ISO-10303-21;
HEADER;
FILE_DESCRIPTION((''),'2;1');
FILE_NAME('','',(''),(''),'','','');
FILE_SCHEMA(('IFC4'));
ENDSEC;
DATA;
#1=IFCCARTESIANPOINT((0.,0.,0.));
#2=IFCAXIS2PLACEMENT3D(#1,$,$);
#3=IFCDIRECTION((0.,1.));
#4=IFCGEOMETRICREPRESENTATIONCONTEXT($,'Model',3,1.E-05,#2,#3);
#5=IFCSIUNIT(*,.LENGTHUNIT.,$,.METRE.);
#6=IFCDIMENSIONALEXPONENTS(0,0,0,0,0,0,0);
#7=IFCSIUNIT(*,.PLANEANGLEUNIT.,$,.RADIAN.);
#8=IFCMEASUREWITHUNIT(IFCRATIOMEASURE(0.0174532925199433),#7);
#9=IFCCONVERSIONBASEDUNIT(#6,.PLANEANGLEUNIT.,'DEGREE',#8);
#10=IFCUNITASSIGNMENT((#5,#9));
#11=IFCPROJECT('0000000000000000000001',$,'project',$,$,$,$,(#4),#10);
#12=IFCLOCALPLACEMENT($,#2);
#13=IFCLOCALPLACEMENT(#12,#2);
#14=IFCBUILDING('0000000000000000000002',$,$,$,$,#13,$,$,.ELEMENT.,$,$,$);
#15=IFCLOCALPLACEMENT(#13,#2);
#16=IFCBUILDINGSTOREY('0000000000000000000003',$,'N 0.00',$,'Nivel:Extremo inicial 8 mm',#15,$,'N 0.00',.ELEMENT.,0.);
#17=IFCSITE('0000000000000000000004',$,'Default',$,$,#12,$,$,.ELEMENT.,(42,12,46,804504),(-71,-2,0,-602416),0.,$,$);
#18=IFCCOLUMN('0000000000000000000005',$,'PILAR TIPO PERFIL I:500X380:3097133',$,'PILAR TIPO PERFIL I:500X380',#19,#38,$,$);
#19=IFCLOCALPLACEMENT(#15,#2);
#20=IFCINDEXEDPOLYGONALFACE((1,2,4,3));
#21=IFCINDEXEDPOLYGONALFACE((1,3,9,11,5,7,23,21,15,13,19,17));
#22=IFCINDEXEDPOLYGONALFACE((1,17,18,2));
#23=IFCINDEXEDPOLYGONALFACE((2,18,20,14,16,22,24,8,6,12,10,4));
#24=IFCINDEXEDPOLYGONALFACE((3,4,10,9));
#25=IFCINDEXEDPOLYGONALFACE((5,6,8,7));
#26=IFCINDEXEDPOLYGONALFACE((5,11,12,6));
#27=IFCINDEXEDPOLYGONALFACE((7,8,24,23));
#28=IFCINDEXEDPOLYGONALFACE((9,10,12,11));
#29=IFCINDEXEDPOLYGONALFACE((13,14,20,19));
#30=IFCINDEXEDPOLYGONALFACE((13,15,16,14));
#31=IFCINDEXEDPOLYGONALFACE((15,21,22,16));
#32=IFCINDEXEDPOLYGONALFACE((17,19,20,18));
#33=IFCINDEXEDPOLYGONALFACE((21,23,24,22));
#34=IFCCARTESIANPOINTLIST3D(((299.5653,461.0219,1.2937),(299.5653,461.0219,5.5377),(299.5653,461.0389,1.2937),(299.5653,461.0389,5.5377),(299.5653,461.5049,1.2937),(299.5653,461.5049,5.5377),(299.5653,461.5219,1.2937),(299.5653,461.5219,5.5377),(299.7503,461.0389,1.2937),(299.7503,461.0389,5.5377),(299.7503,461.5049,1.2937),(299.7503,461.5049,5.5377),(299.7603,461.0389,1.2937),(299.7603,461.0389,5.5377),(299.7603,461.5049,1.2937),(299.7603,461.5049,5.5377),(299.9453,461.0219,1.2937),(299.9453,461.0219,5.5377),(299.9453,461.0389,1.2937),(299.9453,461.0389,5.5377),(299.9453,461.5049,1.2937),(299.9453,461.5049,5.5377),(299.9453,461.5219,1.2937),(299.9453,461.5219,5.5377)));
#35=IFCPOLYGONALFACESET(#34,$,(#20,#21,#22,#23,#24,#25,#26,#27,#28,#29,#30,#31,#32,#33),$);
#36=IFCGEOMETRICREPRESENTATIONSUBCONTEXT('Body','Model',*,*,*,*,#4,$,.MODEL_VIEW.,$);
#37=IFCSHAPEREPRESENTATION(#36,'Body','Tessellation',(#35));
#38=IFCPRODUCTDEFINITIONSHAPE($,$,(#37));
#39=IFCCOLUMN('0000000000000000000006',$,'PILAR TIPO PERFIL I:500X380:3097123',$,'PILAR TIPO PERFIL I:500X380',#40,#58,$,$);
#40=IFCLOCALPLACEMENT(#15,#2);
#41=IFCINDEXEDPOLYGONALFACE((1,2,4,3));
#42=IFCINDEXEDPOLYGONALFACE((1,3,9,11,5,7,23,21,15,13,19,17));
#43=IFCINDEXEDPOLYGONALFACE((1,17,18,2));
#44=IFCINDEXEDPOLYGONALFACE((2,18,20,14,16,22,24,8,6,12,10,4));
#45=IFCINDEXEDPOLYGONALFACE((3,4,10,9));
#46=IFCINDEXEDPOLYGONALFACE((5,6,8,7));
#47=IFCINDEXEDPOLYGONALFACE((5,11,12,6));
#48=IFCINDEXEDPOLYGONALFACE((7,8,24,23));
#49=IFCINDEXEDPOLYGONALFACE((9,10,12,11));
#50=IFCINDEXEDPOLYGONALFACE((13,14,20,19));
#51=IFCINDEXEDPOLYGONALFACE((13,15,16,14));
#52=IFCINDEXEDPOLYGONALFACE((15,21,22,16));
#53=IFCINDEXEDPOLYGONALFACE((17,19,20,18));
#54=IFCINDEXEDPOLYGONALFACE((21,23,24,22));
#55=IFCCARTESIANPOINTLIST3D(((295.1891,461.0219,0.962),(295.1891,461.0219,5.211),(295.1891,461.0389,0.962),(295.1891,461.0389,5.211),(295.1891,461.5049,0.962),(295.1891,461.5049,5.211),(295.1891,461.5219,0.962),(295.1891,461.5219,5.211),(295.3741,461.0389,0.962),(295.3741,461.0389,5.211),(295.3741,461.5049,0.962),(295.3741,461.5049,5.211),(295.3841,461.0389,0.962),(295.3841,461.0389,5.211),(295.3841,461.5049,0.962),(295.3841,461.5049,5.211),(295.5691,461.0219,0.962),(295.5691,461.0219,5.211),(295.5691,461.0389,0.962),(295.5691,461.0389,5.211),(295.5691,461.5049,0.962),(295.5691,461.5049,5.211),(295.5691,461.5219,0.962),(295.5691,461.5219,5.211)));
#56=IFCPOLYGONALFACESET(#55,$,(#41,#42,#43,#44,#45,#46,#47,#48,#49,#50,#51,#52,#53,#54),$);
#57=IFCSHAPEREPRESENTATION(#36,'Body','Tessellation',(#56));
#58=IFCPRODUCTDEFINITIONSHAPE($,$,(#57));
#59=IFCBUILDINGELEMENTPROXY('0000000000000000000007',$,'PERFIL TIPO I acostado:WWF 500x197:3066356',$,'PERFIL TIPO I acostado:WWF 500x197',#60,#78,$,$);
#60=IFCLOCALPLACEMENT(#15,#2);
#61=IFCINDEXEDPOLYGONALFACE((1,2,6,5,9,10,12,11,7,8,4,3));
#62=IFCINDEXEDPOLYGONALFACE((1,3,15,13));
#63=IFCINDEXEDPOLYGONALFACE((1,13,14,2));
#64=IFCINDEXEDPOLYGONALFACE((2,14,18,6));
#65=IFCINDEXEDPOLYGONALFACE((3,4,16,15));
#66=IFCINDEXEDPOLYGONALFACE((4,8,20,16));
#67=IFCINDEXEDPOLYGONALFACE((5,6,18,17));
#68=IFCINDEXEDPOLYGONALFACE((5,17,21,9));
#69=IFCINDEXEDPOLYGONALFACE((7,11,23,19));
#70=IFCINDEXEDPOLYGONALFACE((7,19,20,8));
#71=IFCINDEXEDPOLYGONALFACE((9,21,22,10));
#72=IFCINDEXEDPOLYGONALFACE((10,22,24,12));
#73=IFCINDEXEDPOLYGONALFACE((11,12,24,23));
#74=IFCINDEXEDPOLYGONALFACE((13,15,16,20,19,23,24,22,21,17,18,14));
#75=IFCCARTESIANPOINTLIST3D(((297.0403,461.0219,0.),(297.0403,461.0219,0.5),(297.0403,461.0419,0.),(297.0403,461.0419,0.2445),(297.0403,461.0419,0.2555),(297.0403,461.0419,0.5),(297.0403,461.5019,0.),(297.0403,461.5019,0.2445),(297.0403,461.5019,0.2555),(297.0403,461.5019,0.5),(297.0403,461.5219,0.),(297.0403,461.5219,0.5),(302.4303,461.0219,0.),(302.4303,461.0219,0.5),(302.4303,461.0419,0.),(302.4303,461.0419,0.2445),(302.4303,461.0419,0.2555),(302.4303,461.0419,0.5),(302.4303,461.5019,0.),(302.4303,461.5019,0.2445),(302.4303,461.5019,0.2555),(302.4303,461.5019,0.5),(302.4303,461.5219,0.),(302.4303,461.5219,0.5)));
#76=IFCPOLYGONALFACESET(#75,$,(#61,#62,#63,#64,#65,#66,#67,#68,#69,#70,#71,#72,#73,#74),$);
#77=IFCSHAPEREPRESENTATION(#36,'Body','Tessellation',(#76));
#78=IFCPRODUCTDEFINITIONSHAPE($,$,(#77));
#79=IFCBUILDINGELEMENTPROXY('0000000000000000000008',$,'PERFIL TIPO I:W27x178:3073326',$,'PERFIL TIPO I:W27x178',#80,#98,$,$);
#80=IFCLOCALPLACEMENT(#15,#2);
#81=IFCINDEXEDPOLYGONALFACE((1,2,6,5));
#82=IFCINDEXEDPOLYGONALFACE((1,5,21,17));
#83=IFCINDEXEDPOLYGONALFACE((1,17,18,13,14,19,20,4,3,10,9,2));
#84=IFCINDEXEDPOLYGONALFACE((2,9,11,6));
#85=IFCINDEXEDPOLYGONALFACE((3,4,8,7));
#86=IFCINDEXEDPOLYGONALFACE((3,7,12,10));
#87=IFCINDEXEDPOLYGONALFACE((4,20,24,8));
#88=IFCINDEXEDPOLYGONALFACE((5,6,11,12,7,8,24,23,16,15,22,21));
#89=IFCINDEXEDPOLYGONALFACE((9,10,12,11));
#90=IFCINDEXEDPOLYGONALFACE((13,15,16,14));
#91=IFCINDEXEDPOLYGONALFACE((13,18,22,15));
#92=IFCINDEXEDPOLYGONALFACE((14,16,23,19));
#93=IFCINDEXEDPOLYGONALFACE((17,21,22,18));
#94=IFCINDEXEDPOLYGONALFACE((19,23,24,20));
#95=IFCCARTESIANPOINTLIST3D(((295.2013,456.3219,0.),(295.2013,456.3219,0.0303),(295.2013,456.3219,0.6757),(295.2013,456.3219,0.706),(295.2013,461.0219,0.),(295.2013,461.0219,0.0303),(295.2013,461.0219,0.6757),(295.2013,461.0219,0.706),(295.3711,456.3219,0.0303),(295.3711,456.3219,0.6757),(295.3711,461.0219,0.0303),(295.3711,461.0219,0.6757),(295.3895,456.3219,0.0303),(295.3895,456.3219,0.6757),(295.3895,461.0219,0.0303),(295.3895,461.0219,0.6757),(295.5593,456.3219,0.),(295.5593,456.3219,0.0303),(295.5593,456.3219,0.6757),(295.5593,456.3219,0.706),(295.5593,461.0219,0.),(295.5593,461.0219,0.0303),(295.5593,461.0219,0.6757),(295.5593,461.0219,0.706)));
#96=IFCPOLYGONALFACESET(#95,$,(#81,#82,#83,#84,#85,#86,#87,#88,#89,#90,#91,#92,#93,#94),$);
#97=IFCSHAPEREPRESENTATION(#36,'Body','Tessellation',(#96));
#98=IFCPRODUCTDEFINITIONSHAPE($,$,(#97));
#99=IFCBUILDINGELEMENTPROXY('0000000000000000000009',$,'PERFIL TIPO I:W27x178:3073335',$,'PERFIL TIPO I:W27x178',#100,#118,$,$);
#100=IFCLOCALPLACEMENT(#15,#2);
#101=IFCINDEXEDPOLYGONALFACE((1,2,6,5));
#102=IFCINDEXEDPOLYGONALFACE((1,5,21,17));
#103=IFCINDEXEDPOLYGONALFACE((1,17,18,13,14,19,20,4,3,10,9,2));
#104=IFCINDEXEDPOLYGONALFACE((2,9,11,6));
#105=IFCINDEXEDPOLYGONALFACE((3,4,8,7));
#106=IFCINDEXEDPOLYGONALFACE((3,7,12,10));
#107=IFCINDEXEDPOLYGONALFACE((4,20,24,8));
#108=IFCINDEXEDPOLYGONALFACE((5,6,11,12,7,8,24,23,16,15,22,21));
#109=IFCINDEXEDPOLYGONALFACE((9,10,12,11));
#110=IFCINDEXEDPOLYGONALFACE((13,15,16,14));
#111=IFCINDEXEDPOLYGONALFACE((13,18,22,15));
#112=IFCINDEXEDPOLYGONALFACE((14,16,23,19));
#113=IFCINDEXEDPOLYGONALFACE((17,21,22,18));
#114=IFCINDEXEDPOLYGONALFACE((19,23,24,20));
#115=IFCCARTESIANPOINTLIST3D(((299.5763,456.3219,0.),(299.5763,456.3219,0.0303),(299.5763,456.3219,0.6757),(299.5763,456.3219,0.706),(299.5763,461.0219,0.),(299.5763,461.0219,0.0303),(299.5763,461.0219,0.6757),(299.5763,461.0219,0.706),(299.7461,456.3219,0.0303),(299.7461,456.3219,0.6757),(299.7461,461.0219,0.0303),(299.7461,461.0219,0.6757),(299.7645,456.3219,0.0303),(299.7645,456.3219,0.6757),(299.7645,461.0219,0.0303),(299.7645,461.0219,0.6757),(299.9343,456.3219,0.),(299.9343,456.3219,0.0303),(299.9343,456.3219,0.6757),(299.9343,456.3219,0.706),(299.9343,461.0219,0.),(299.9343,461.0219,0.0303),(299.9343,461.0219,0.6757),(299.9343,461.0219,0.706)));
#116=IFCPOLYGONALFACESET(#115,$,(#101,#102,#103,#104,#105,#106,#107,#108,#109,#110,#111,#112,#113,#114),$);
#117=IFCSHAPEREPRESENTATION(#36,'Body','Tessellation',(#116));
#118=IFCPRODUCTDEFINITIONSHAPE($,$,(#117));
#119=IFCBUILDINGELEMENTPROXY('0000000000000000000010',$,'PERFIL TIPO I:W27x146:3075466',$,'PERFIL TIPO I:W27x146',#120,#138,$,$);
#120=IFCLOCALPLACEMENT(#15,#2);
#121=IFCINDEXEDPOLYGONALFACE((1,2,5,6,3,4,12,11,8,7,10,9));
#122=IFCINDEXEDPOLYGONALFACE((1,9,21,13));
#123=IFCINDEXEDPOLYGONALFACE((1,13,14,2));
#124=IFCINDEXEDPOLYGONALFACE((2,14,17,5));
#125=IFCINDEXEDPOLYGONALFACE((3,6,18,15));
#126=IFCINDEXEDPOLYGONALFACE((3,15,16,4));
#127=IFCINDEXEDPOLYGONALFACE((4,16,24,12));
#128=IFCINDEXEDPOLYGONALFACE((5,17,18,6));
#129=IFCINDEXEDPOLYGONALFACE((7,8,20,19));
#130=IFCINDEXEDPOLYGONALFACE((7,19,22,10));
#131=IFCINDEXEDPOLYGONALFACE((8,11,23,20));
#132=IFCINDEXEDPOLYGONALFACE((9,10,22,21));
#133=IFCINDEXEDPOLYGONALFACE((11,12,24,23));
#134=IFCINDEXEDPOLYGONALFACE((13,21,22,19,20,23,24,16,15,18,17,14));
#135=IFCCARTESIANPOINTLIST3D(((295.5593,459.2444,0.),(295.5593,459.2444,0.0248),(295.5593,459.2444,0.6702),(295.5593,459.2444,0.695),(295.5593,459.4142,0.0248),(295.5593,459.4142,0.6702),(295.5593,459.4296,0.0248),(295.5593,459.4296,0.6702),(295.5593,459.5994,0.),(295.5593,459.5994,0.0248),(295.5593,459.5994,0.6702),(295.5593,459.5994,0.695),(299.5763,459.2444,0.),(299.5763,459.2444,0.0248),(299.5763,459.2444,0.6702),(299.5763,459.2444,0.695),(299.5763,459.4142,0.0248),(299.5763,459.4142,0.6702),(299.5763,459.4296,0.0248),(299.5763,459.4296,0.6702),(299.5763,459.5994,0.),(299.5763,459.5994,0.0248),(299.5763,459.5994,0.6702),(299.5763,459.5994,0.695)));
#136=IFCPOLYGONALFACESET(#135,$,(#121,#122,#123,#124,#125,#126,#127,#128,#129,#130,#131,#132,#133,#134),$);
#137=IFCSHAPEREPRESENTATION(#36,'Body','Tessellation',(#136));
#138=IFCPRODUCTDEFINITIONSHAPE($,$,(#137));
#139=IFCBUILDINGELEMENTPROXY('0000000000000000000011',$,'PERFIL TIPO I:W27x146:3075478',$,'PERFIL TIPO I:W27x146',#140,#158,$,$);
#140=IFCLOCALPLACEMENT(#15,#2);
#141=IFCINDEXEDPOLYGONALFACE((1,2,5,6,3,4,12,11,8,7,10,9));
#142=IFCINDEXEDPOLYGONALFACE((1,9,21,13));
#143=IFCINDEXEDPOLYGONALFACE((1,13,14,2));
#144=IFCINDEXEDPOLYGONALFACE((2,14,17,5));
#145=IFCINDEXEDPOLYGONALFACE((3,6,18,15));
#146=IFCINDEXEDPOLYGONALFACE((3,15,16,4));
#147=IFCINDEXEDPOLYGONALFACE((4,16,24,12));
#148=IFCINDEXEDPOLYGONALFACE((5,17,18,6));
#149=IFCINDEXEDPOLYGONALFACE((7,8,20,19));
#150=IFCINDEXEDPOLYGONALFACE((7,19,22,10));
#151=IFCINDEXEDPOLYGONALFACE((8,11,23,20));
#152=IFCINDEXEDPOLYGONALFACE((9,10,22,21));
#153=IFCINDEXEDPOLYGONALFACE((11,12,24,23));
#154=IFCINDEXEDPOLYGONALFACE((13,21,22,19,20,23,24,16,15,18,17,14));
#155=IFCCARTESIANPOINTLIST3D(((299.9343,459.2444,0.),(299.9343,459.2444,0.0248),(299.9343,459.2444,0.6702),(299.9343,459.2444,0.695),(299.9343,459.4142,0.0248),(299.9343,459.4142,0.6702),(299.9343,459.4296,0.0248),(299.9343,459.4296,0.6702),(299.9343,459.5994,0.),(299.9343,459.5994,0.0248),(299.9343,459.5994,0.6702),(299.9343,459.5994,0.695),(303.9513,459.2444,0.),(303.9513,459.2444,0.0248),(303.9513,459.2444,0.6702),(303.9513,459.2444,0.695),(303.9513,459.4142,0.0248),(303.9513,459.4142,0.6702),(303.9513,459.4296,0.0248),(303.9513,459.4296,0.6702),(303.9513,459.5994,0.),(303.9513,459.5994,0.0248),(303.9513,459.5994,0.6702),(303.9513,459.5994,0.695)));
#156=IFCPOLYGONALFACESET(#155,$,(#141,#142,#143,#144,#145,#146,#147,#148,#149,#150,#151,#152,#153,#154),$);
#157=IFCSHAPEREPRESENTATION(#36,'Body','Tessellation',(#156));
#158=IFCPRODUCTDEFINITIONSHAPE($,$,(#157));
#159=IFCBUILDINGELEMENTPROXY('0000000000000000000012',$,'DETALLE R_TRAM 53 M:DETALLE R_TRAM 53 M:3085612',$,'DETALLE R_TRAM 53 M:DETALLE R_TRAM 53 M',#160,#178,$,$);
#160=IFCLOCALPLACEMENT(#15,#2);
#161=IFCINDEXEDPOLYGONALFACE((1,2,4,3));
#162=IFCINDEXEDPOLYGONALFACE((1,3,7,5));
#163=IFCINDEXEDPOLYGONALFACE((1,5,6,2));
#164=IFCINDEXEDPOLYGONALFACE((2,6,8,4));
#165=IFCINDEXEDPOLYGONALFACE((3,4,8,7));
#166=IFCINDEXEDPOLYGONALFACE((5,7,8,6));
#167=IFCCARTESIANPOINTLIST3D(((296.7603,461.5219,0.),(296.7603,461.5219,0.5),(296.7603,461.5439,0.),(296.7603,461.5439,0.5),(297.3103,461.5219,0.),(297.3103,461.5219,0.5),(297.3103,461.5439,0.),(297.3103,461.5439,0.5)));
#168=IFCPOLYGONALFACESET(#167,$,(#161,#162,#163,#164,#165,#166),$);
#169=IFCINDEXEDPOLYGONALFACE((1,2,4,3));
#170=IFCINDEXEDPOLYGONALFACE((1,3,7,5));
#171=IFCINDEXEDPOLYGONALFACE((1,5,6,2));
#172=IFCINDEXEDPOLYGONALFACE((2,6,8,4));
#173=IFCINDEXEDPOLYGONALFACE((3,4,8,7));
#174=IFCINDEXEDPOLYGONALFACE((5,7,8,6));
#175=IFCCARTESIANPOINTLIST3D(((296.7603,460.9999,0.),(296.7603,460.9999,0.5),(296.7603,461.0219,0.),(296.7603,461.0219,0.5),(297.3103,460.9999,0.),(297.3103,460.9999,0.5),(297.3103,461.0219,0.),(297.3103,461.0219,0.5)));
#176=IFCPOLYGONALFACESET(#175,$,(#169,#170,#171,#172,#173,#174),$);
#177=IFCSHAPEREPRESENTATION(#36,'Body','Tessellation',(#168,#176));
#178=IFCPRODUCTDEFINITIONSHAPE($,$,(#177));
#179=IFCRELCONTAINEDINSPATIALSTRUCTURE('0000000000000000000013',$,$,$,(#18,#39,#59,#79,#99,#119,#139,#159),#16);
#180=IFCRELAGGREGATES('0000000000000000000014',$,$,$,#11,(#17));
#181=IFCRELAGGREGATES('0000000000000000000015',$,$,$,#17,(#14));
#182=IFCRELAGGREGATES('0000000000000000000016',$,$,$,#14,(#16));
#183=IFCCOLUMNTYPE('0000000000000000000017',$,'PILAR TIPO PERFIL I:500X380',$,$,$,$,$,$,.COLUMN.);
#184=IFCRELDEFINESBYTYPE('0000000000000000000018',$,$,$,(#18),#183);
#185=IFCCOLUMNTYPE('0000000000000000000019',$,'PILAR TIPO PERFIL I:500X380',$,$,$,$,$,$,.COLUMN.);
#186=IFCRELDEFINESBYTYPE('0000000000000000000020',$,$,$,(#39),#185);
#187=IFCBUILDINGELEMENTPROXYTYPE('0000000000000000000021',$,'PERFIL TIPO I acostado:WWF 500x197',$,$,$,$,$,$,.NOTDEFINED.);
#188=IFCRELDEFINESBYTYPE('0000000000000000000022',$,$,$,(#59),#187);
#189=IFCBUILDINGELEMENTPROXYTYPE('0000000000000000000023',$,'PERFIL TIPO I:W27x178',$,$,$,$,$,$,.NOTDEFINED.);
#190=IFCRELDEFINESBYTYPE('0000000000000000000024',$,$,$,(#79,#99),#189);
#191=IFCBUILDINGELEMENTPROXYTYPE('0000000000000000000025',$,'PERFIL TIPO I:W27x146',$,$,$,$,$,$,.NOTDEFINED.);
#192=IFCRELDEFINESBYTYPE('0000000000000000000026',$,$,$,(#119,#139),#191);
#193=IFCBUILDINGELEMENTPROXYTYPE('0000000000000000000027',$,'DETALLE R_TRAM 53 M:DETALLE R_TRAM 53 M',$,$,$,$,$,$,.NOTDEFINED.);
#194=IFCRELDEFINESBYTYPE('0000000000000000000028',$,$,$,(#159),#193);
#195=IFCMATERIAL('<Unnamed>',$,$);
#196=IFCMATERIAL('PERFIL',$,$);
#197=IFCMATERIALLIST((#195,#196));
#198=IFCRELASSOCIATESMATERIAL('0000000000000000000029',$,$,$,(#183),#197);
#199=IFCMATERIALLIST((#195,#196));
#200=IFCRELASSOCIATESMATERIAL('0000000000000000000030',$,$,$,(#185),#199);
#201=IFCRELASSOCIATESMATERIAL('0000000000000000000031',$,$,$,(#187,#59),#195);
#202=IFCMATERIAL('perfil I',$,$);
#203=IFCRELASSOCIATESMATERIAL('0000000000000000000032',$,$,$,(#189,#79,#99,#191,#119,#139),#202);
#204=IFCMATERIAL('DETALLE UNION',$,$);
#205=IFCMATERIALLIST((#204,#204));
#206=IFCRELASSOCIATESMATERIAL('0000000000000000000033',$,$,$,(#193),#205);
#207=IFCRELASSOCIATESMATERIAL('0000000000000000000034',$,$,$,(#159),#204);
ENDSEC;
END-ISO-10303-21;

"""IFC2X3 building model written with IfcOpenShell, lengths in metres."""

from ifc_helpers import new_model, entity, si_unit, converted_unit, direction, frame, frame_2d, origin, place, context, subcontext, project, spatial, polyline, rectangle, i_section, outline, extrude, source, transform, mapped, material, material_list, type_object, type_shapes, element, save


model = new_model("IFC2X3")

# Units and contexts
model_context = context("Model", 3, precision=1e-05, world=origin(), true_north=direction((0.0, 1.0)))
body_context = subcontext(model_context, "Body", "Model", "MODEL_VIEW")
ifc_project = project(units=[si_unit("LENGTHUNIT", "METRE"), converted_unit("PLANEANGLEUNIT", "DEGREE", entity("IfcRatioMeasure", 0.0174532925199433), si_unit("PLANEANGLEUNIT", "RADIAN"), dimensions=[0, 0, 0, 0, 0, 0, 0])], contexts=[model_context])

# Site, building, storey
site_placement = place(None, origin())
site = spatial("IfcSite", under=ifc_project, at=site_placement, Name="Default", CompositionType="ELEMENT", RefLatitude=(42, 12, 46, 804504), RefLongitude=(-71, -2, 0, -602416), RefElevation=0.0)
building_placement = place(site_placement, origin())
building = spatial("IfcBuilding", under=site, at=building_placement, CompositionType="ELEMENT")
storey_placement = place(building_placement, origin())
storey = spatial("IfcBuildingStorey", under=building, at=storey_placement, Name="N 0.00", ObjectType="Nivel:Extremo inicial 8 mm", LongName="N 0.00", CompositionType="ELEMENT", Elevation=0.0)

# Columns
ifc_material_1 = material(Name="<Unnamed>")
ifc_material_2 = material(Name="PERFIL")
ifc_material_list_1 = material_list([ifc_material_1, ifc_material_2])
column_type_1 = type_object("IfcColumnType", Name="PILAR TIPO PERFIL I:500X380", PredefinedType="COLUMN", material=ifc_material_list_1)
shared_shape_1 = source(origin(), body_context, "Body", "SweptSolid", [
    extrude(i_section(OverallWidth=0.38, OverallDepth=0.5, WebThickness=0.01, FlangeThickness=0.017, at=frame_2d((0.0, 0.0), x_axis=(1.0, 0.0))), frame((0.0, 0.0, 1.2937), z_axis=(0.0, 0.0, 1.0), x_axis=(0.0, -1.0, 0.0)), (0.0, 0.0, 1.0), 4.244),
])
type_shapes(column_type_1, [shared_shape_1])
column_1_placement = place(storey_placement, frame((299.7553, 461.2719, 0.0), z_axis=(0.0, 0.0, 1.0), x_axis=(0.0, -1.0, 0.0)))
element("IfcColumn", 1, at=column_1_placement, inside=storey, type_object=column_type_1, Name="PILAR TIPO PERFIL I:500X380:3097133", ObjectType="PILAR TIPO PERFIL I:500X380", context=body_context, shape_type="MappedRepresentation", body=[
    mapped(shared_shape_1, transform((0.0, 0.0, 0.0), scale=1.0)),
])
ifc_material_list_2 = material_list([ifc_material_1, ifc_material_2])
column_type_2 = type_object("IfcColumnType", Name="PILAR TIPO PERFIL I:500X380", PredefinedType="COLUMN", material=ifc_material_list_2)
shared_shape_2 = source(origin(), body_context, "Body", "SweptSolid", [
    extrude(i_section(OverallWidth=0.38, OverallDepth=0.5, WebThickness=0.01, FlangeThickness=0.017, at=frame_2d((0.0, 0.0), x_axis=(1.0, 0.0))), frame((0.0, 0.0, 0.962), z_axis=(0.0, 0.0, 1.0), x_axis=(0.0, -1.0, 0.0)), (0.0, 0.0, 1.0), 4.249),
])
type_shapes(column_type_2, [shared_shape_2])
column_2_placement = place(storey_placement, frame((295.3791, 461.2719, 0.0), z_axis=(0.0, 0.0, 1.0), x_axis=(0.0, -1.0, 0.0)))
element("IfcColumn", 2, at=column_2_placement, inside=storey, type_object=column_type_2, Name="PILAR TIPO PERFIL I:500X380:3097123", ObjectType="PILAR TIPO PERFIL I:500X380", context=body_context, shape_type="MappedRepresentation", body=[
    mapped(shared_shape_2, transform((0.0, 0.0, 0.0), scale=1.0)),
])

# Building element proxies
building_element_proxy_type_1 = type_object("IfcBuildingElementProxyType", Name="PERFIL TIPO I acostado:WWF 500x197", PredefinedType="NOTDEFINED", material=ifc_material_1)
shared_shape_3 = source(origin(), body_context, "Body", "SweptSolid", [
    extrude(outline(polyline([(-0.25, -0.23), (-0.25, -0.25), (0.25, -0.25), (0.25, -0.23), (0.0055, -0.23), (0.0055, 0.23), (0.25, 0.23), (0.25, 0.25), (-0.25, 0.25), (-0.25, 0.23), (-0.0055, 0.23), (-0.0055, -0.23), (-0.25, -0.23)])), frame((0.0, 0.0, 0.25), z_axis=(-1.0, 0.0, 0.0), x_axis=(0.0, 0.0, -1.0)), (0.0, 0.0, -1.0), 5.39),
])
type_shapes(building_element_proxy_type_1, [shared_shape_3])
proxy_1_placement = place(storey_placement, frame((297.0403, 461.2719, 0.0)))
element("IfcBuildingElementProxy", 3, at=proxy_1_placement, inside=storey, type_object=building_element_proxy_type_1, material=ifc_material_1, Name="PERFIL TIPO I acostado:WWF 500x197:3066356", ObjectType="PERFIL TIPO I acostado:WWF 500x197", context=body_context, shape_type="MappedRepresentation", body=[
    mapped(shared_shape_3, transform((0.0, 0.0, 0.0), scale=1.0)),
])
ifc_material_3 = material(Name="perfil I")
building_element_proxy_type_2 = type_object("IfcBuildingElementProxyType", Name="PERFIL TIPO I:W27x178", PredefinedType="NOTDEFINED", material=ifc_material_3)
shared_shape_4 = source(origin(), body_context, "Body", "SweptSolid", [
    extrude(outline(polyline([(0.3227, -0.179), (0.353, -0.179), (0.353, 0.179), (0.3227, 0.179), (0.3227, 0.0092), (-0.3227, 0.0092), (-0.3227, 0.179), (-0.353, 0.179), (-0.353, -0.179), (-0.3227, -0.179), (-0.3227, -0.0092), (0.3227, -0.0092), (0.3227, -0.179)])), frame((0.0, 0.0, 0.353), z_axis=(1.0, 0.0, 0.0), x_axis=(0.0, 0.0, 1.0)), (0.0, 0.0, 1.0), 4.7),
])
type_shapes(building_element_proxy_type_2, [shared_shape_4])
for number, where, z_axis, x_axis, name in (
    (4, (295.3803, 461.0219, 0.0), (0.0, 0.0, 1.0), (0.0, -1.0, 0.0), "PERFIL TIPO I:W27x178:3073326"),
    (5, (299.7553, 461.0219, 0.0), (0.0, 0.0, 1.0), (0.0, -1.0, 0.0), "PERFIL TIPO I:W27x178:3073335"),
):
    element("IfcBuildingElementProxy", number, at=place(storey_placement, frame(where, z_axis=z_axis, x_axis=x_axis)), inside=storey, type_object=building_element_proxy_type_2, material=ifc_material_3, Name=name, ObjectType="PERFIL TIPO I:W27x178", context=body_context, shape_type="MappedRepresentation", body=[
        mapped(shared_shape_4, transform((0.0, 0.0, 0.0), scale=1.0)),
    ])
building_element_proxy_type_3 = type_object("IfcBuildingElementProxyType", Name="PERFIL TIPO I:W27x146", PredefinedType="NOTDEFINED", material=ifc_material_3)
shared_shape_5 = source(origin(), body_context, "Body", "SweptSolid", [
    extrude(outline(polyline([(0.3227, -0.1775), (0.3475, -0.1775), (0.3475, 0.1775), (0.3227, 0.1775), (0.3227, 0.0077), (-0.3227, 0.0077), (-0.3227, 0.1775), (-0.3475, 0.1775), (-0.3475, -0.1775), (-0.3227, -0.1775), (-0.3227, -0.0077), (0.3227, -0.0077), (0.3227, -0.1775)])), frame((0.0, 0.0, 0.3475), z_axis=(1.0, 0.0, 0.0), x_axis=(0.0, 0.0, 1.0)), (0.0, 0.0, 1.0), 4.017),
])
type_shapes(building_element_proxy_type_3, [shared_shape_5])
for number, where, name in (
    (6, (295.5593, 459.4219, 0.0), "PERFIL TIPO I:W27x146:3075466"),
    (7, (299.9343, 459.4219, 0.0), "PERFIL TIPO I:W27x146:3075478"),
):
    element("IfcBuildingElementProxy", number, at=place(storey_placement, frame(where)), inside=storey, type_object=building_element_proxy_type_3, material=ifc_material_3, Name=name, ObjectType="PERFIL TIPO I:W27x146", context=body_context, shape_type="MappedRepresentation", body=[
        mapped(shared_shape_5, transform((0.0, 0.0, 0.0), scale=1.0)),
    ])
ifc_material_4 = material(Name="DETALLE UNION")
ifc_material_list_3 = material_list([ifc_material_4, ifc_material_4])
building_element_proxy_type_4 = type_object("IfcBuildingElementProxyType", Name="DETALLE R_TRAM 53 M:DETALLE R_TRAM 53 M", PredefinedType="NOTDEFINED", material=ifc_material_list_3)
shared_shape_6 = source(origin(), body_context, "Body", "SweptSolid", [
    extrude(rectangle(XDim=0.55, YDim=0.022, at=frame_2d((0.0, 0.0), x_axis=(1.0, 0.0))), frame((0.275, 0.011, 0.0), z_axis=(0.0, 0.0, 1.0), x_axis=(-1.0, 0.0, 0.0)), (0.0, 0.0, 1.0), 0.5),
    extrude(rectangle(XDim=0.55, YDim=0.022, at=frame_2d((0.0, 0.0), x_axis=(1.0, 0.0))), frame((0.275, -0.511, 0.0), z_axis=(0.0, 0.0, 1.0), x_axis=(-1.0, 0.0, 0.0)), (0.0, 0.0, 1.0), 0.5),
])
type_shapes(building_element_proxy_type_4, [shared_shape_6])
proxy_2_placement = place(storey_placement, frame((296.7603, 461.5219, 0.0)))
element("IfcBuildingElementProxy", 8, at=proxy_2_placement, inside=storey, type_object=building_element_proxy_type_4, material=ifc_material_4, Name="DETALLE R_TRAM 53 M:DETALLE R_TRAM 53 M:3085612", ObjectType="DETALLE R_TRAM 53 M:DETALLE R_TRAM 53 M", context=body_context, shape_type="MappedRepresentation", body=[
    mapped(shared_shape_6, transform((0.0, 0.0, 0.0), scale=1.0)),
])

save(model, "model.ifc")
